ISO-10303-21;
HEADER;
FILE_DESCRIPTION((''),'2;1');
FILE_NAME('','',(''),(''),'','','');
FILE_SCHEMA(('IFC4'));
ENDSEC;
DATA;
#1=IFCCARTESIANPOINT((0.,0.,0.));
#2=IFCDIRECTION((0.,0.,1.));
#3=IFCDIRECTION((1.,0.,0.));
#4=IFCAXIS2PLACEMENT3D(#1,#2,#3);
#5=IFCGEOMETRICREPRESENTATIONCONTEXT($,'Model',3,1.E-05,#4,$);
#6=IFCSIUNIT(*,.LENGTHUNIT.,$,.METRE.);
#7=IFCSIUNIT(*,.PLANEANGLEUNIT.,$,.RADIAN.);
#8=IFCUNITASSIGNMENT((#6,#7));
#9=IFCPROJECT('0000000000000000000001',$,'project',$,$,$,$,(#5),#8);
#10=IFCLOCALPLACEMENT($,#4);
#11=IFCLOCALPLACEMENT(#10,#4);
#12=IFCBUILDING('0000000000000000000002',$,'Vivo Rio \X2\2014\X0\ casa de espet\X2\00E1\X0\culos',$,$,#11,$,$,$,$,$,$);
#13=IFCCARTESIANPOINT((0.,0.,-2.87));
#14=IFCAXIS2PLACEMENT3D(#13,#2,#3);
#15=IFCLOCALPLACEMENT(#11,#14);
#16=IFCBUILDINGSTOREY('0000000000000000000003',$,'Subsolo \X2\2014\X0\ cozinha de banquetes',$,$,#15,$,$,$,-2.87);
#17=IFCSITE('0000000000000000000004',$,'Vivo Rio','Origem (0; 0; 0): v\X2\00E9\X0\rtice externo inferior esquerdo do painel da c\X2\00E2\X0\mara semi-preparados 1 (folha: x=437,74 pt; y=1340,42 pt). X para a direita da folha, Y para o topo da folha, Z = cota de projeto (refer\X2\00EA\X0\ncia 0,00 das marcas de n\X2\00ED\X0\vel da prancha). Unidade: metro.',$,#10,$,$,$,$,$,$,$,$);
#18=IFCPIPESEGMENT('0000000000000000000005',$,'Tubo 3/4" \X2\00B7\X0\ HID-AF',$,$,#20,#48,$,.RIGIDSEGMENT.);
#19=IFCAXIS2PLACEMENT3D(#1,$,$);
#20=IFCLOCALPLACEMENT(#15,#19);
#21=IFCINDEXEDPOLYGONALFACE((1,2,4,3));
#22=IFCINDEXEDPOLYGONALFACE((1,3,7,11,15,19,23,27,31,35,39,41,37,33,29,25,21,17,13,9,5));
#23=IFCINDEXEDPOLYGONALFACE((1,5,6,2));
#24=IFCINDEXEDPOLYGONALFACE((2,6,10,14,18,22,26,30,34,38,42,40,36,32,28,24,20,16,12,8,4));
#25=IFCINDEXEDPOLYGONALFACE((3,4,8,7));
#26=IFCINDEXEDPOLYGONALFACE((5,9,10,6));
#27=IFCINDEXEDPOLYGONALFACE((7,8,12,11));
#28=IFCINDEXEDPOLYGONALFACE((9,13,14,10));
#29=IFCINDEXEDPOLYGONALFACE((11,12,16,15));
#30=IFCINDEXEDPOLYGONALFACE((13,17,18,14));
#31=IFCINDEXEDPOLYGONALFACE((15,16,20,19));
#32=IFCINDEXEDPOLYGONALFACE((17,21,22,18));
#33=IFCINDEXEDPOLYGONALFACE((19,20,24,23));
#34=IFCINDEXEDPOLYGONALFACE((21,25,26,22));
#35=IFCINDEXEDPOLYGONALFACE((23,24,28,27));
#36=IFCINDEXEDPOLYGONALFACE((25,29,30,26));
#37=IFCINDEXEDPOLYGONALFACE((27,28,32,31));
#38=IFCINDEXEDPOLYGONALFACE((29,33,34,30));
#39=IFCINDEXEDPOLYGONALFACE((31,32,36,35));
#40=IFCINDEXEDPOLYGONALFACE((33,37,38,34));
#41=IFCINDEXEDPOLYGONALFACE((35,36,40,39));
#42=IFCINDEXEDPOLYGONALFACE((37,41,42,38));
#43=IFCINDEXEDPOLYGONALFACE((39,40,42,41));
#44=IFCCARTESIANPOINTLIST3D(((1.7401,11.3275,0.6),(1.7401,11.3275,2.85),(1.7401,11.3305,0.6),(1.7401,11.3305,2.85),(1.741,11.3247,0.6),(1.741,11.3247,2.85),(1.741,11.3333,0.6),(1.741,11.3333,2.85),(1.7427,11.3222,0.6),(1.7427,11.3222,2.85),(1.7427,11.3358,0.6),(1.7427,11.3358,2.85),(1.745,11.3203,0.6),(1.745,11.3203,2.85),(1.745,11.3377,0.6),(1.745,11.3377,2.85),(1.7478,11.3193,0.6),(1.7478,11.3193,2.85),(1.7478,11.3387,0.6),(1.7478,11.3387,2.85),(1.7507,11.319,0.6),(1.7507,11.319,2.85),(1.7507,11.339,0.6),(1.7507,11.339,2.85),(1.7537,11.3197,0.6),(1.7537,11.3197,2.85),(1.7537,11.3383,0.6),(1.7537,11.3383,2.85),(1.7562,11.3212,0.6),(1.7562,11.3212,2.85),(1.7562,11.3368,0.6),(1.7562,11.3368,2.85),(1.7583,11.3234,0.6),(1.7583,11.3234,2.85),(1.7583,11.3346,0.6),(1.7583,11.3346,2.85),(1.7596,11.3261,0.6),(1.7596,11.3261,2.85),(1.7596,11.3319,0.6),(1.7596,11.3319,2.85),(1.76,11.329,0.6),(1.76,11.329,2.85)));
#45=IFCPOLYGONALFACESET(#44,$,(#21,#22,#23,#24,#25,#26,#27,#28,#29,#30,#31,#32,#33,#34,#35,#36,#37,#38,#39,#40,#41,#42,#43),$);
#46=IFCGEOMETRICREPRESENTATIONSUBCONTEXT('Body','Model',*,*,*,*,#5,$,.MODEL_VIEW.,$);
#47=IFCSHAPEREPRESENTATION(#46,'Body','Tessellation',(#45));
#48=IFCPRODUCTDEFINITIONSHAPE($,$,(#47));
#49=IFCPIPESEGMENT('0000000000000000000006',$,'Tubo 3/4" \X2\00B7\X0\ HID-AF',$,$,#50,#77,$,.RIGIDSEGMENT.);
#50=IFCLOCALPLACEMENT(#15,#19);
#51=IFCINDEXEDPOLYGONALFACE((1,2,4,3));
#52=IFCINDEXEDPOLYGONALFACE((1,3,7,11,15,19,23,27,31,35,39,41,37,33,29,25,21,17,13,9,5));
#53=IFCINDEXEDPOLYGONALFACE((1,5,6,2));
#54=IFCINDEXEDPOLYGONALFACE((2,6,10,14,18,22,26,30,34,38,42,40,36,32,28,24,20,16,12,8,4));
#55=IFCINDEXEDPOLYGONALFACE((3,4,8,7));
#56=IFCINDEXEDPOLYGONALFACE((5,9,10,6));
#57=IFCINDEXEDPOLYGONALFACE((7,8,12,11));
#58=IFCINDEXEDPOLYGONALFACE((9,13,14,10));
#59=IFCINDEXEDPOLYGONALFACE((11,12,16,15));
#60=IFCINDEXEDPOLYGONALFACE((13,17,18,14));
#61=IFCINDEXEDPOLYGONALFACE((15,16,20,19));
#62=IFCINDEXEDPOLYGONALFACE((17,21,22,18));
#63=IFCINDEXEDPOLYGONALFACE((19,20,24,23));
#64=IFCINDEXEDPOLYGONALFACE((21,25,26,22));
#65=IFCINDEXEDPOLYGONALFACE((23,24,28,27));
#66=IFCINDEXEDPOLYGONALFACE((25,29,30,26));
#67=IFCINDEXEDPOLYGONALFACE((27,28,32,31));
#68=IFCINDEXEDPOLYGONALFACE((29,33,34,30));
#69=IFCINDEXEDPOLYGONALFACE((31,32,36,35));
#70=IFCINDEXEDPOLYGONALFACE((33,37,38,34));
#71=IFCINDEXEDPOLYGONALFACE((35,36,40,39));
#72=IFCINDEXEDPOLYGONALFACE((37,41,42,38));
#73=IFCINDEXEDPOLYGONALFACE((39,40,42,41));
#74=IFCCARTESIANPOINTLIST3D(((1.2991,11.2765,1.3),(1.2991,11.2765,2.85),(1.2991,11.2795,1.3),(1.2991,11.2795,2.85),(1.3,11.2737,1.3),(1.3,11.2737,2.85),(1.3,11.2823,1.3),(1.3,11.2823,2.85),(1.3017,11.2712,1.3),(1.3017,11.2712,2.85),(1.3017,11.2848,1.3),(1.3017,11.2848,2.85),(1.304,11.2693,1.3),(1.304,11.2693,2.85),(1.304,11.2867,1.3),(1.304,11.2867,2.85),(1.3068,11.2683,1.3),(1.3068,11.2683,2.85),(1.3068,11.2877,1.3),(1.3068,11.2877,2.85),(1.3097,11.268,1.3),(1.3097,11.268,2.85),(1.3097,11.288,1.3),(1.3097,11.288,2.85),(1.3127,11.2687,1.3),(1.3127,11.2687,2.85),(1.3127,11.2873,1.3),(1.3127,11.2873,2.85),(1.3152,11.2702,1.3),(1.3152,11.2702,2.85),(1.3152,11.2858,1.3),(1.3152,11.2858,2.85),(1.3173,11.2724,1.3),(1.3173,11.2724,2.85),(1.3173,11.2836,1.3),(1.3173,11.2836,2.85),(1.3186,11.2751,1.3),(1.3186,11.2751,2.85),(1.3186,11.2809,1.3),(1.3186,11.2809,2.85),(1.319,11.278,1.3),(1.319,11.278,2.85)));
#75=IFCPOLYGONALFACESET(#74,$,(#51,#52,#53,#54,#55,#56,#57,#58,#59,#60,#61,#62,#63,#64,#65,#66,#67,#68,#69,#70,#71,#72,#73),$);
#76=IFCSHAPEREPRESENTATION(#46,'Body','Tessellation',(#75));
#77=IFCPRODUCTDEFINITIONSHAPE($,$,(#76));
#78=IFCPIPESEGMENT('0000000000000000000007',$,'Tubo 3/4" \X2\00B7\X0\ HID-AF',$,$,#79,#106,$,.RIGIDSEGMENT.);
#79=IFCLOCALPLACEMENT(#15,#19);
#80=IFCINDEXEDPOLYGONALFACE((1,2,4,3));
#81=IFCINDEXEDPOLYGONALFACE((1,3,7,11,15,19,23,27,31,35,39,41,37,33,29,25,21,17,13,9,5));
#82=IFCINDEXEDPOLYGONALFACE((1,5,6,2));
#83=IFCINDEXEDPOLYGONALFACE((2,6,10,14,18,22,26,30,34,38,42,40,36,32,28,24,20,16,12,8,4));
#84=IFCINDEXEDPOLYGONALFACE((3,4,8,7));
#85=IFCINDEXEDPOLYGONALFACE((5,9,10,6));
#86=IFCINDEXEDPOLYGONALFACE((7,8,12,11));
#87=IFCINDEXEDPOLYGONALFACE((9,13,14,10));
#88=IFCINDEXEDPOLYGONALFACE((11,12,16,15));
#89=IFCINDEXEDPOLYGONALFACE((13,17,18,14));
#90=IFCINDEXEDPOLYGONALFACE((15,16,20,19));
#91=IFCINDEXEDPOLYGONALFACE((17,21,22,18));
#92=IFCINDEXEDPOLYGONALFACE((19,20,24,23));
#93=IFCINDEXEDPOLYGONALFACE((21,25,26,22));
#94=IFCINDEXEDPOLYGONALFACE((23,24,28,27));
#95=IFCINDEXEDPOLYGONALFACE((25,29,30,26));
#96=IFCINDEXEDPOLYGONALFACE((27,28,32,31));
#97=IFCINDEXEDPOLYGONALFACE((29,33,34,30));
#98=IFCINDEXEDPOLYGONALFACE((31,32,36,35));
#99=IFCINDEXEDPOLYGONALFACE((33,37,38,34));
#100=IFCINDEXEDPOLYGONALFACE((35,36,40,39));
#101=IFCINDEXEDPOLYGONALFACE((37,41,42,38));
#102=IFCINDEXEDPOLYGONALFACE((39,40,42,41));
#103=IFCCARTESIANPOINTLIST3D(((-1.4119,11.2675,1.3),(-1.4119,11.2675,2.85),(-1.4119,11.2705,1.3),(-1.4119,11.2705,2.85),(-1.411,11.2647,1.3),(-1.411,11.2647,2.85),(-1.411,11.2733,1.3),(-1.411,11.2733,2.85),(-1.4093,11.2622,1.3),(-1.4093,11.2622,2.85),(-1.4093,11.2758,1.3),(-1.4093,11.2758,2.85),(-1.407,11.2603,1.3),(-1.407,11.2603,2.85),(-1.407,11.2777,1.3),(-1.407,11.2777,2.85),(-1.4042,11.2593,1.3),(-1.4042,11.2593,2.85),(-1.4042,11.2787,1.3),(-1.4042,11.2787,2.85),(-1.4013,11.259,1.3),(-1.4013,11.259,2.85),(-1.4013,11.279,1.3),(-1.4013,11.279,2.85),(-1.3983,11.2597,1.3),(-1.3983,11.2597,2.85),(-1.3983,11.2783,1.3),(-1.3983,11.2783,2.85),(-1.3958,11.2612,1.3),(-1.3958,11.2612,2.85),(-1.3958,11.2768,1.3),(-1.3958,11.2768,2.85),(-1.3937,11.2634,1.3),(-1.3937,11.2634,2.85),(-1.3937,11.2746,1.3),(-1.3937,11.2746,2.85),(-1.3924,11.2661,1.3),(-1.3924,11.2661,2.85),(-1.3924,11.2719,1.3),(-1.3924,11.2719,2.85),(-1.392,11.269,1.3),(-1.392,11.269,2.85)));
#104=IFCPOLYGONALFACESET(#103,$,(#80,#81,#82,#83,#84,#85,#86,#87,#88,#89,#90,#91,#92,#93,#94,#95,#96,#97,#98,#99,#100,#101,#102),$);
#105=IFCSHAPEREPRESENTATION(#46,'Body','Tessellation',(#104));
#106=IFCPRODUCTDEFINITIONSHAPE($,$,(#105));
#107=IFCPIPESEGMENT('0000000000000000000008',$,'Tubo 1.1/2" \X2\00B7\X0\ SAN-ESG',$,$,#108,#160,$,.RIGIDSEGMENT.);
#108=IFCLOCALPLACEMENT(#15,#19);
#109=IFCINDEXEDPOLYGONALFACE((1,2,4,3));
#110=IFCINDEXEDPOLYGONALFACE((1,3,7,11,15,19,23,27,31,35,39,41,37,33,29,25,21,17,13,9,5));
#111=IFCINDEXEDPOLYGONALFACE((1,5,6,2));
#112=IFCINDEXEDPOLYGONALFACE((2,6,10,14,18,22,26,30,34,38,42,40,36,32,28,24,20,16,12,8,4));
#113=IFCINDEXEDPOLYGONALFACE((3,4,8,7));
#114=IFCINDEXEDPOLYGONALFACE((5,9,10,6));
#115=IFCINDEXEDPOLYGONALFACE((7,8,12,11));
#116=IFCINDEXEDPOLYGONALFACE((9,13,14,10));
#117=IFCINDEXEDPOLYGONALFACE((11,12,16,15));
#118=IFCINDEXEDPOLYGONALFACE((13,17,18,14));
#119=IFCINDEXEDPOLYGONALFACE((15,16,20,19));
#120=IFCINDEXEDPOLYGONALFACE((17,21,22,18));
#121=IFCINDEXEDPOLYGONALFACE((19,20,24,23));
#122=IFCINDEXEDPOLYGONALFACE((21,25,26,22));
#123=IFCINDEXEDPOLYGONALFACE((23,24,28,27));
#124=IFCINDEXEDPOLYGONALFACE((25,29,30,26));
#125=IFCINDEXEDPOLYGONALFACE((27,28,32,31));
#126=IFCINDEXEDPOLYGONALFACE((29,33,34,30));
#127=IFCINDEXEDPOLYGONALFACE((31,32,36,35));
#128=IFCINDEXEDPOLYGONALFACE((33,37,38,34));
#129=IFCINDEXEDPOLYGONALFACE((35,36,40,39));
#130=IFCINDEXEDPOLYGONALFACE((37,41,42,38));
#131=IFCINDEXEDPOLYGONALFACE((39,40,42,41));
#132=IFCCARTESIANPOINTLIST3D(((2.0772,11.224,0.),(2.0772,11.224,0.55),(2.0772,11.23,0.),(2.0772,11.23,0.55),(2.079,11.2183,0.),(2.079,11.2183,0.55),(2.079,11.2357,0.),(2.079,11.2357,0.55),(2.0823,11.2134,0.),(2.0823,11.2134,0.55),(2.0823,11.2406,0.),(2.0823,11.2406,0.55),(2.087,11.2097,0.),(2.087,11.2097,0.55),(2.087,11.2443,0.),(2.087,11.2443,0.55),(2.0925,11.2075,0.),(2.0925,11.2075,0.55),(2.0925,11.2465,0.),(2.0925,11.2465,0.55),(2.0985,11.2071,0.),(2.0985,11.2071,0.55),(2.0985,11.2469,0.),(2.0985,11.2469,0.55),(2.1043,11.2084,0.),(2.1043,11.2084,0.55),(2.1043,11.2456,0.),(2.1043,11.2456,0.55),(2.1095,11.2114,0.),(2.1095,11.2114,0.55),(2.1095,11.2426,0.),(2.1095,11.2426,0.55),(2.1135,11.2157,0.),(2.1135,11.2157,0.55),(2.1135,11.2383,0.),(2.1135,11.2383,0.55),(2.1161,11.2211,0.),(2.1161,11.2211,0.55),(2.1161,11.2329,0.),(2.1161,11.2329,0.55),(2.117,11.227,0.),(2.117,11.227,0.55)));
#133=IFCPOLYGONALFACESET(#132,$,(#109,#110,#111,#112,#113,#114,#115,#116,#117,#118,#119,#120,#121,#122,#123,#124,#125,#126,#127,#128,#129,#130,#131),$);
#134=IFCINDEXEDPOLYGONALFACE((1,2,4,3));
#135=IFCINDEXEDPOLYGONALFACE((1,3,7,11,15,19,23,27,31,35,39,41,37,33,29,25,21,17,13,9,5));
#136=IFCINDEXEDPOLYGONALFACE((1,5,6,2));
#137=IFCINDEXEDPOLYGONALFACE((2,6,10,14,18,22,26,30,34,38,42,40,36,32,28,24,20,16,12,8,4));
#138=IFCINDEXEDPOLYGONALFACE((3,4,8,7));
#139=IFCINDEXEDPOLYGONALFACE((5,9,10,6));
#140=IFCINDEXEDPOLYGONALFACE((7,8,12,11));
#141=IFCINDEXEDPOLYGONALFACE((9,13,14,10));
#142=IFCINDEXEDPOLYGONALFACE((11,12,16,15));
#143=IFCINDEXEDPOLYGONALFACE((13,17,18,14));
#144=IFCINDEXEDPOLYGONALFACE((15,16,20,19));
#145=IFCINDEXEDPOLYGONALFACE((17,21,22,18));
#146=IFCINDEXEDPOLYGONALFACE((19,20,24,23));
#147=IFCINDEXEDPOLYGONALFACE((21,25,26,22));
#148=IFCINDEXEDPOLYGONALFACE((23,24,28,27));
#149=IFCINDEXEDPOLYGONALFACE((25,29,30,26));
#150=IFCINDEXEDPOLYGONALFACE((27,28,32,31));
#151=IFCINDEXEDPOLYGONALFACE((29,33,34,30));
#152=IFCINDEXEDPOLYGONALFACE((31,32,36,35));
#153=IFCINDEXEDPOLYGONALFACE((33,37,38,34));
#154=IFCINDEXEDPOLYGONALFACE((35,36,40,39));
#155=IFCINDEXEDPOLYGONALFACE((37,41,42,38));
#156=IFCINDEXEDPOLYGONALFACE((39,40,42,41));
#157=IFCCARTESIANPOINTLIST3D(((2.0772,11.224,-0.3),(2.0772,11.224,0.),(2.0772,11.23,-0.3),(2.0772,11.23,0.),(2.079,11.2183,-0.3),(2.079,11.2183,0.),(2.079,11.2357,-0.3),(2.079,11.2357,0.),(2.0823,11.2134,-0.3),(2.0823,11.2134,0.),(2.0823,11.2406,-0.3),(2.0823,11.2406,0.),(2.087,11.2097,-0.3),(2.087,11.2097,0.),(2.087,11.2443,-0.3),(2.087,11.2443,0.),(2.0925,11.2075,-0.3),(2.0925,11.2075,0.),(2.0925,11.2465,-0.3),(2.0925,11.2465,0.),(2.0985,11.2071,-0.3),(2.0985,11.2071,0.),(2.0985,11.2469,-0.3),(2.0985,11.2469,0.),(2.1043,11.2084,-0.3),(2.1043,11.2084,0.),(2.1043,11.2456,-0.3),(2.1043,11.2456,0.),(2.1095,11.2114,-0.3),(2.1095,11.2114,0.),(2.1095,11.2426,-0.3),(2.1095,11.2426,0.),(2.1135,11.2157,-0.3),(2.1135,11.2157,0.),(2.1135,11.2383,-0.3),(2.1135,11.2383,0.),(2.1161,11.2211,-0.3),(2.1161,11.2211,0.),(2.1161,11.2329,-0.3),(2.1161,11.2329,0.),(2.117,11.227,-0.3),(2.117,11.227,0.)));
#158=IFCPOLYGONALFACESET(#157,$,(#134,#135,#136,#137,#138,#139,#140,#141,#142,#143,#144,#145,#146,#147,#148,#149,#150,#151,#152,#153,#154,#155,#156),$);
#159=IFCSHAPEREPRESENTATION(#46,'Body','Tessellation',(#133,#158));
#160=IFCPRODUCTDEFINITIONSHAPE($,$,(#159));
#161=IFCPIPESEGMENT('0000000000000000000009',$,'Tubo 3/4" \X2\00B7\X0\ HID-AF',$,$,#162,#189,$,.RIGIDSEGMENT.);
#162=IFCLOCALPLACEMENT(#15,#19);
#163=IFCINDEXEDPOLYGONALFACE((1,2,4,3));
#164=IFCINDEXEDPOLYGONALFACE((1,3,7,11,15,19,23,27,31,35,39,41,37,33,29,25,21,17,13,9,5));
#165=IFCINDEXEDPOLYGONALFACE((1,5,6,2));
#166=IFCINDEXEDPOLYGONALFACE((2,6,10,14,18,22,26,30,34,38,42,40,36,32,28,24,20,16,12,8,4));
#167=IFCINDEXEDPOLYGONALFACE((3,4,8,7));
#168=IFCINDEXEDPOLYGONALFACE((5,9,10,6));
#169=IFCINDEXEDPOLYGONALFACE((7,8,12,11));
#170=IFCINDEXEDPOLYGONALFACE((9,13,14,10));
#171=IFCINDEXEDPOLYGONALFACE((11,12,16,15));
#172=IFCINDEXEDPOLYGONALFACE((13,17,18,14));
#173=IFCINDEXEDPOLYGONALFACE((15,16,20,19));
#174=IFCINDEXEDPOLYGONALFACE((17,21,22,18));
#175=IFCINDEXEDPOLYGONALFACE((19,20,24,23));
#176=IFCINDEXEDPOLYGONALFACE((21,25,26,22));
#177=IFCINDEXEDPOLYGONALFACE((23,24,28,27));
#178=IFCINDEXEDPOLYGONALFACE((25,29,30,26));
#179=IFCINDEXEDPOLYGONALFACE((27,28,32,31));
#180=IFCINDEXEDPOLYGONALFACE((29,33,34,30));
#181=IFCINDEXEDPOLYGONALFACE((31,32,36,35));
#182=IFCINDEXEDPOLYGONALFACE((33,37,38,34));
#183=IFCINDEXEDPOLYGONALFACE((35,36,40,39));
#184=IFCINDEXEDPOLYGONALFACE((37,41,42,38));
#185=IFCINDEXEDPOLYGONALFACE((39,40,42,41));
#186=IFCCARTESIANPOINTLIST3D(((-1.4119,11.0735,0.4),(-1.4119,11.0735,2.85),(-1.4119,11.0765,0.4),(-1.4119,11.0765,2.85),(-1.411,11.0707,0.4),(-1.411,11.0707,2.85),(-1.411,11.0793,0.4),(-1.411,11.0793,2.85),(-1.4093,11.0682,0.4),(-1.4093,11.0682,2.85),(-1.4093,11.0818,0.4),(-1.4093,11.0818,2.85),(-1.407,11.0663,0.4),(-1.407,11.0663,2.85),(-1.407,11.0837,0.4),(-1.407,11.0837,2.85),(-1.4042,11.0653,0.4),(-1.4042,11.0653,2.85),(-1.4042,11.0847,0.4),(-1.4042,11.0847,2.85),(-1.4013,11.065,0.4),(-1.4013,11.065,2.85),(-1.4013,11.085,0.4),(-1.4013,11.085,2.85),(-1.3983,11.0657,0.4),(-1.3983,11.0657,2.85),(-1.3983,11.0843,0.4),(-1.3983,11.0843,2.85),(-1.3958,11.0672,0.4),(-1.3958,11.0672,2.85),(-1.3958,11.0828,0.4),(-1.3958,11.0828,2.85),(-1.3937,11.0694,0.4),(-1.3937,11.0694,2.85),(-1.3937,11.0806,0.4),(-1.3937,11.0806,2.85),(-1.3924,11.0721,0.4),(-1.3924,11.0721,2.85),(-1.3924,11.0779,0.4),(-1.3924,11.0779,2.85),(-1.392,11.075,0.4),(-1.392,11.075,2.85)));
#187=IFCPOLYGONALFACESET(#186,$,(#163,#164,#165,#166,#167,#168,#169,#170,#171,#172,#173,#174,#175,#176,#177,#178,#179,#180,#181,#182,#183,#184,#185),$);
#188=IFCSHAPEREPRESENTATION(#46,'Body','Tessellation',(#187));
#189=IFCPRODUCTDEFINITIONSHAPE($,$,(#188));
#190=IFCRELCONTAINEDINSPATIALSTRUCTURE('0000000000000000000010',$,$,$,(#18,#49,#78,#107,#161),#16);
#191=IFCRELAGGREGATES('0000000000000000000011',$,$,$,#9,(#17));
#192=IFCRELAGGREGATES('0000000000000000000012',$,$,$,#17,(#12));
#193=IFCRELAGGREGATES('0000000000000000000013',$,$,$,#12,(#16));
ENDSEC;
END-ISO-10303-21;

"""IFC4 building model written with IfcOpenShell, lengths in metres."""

from ifc_helpers import new_model, si_unit, frame, origin_with_axes, origin_2d, place, context, subcontext, project, spatial, circle, extrude, element, save


model = new_model("IFC4")

# Units and contexts
model_context = context("Model", 3, precision=1e-05, world=origin_with_axes())
body_context = subcontext(model_context, "Body", "Model", "MODEL_VIEW")
ifc_project = project(units=[si_unit("LENGTHUNIT", "METRE"), si_unit("PLANEANGLEUNIT", "RADIAN")], contexts=[model_context])

# Site, building, storey
site_placement = place(None, origin_with_axes())
site = spatial("IfcSite", under=ifc_project, at=site_placement, Name="Vivo Rio", Description="Origem (0; 0; 0): vértice externo inferior esquerdo do painel da câmara semi-preparados 1 (folha: x=437,74 pt; y=1340,42 pt). X para a direita da folha, Y para o topo da folha, Z = cota de projeto (referência 0,00 das marcas de nível da prancha). Unidade: metro.")
building_placement = place(site_placement, origin_with_axes())
building = spatial("IfcBuilding", under=site, at=building_placement, Name="Vivo Rio — casa de espetáculos")
storey_placement = place(building_placement, frame((0.0, 0.0, -2.87), z_axis=(0.0, 0.0, 1.0), x_axis=(1.0, 0.0, 0.0)))
storey = spatial("IfcBuildingStorey", under=building, at=storey_placement, Name="Subsolo — cozinha de banquetes", Elevation=-2.87)

# Pipe segments
pipe_segment_1_placement = place(storey_placement, origin_with_axes())
element("IfcPipeSegment", 1, at=pipe_segment_1_placement, inside=storey, Name="Tubo 3/4\" · HID-AF", PredefinedType="RIGIDSEGMENT", context=body_context, shape_type="SweptSolid", body=[
    extrude(circle(Radius=0.01, at=origin_2d()), frame((1.75, 11.329, 2.85), z_axis=(0.0, 0.0, -1.0), x_axis=(1.0, 0.0, 0.0)), (0.0, 0.0, 1.0), 2.25),
])
pipe_segment_2_placement = place(storey_placement, origin_with_axes())
element("IfcPipeSegment", 2, at=pipe_segment_2_placement, inside=storey, Name="Tubo 3/4\" · HID-AF", PredefinedType="RIGIDSEGMENT", context=body_context, shape_type="SweptSolid", body=[
    extrude(circle(Radius=0.01, at=origin_2d()), frame((1.309, 11.278, 2.85), z_axis=(0.0, 0.0, -1.0), x_axis=(1.0, 0.0, 0.0)), (0.0, 0.0, 1.0), 1.55),
])
pipe_segment_3_placement = place(storey_placement, origin_with_axes())
element("IfcPipeSegment", 3, at=pipe_segment_3_placement, inside=storey, Name="Tubo 3/4\" · HID-AF", PredefinedType="RIGIDSEGMENT", context=body_context, shape_type="SweptSolid", body=[
    extrude(circle(Radius=0.01, at=origin_2d()), frame((-1.402, 11.269, 2.85), z_axis=(0.0, 0.0, -1.0), x_axis=(1.0, 0.0, 0.0)), (0.0, 0.0, 1.0), 1.55),
])
pipe_segment_4_placement = place(storey_placement, origin_with_axes())
element("IfcPipeSegment", 4, at=pipe_segment_4_placement, inside=storey, Name="Tubo 1.1/2\" · SAN-ESG", PredefinedType="RIGIDSEGMENT", context=body_context, shape_type="SweptSolid", body=[
    extrude(circle(Radius=0.02, at=origin_2d()), frame((2.097, 11.227, 0.55), z_axis=(0.0, 0.0, -1.0), x_axis=(1.0, 0.0, 0.0)), (0.0, 0.0, 1.0), 0.55),
    extrude(circle(Radius=0.02, at=origin_2d()), frame((2.097, 11.227, 0.0), z_axis=(0.0, 0.0, -1.0), x_axis=(1.0, 0.0, 0.0)), (0.0, 0.0, 1.0), 0.3),
])
pipe_segment_5_placement = place(storey_placement, origin_with_axes())
element("IfcPipeSegment", 5, at=pipe_segment_5_placement, inside=storey, Name="Tubo 3/4\" · HID-AF", PredefinedType="RIGIDSEGMENT", context=body_context, shape_type="SweptSolid", body=[
    extrude(circle(Radius=0.01, at=origin_2d()), frame((-1.402, 11.075, 2.85), z_axis=(0.0, 0.0, -1.0), x_axis=(1.0, 0.0, 0.0)), (0.0, 0.0, 1.0), 2.45),
])

save(model, "model.ifc")
